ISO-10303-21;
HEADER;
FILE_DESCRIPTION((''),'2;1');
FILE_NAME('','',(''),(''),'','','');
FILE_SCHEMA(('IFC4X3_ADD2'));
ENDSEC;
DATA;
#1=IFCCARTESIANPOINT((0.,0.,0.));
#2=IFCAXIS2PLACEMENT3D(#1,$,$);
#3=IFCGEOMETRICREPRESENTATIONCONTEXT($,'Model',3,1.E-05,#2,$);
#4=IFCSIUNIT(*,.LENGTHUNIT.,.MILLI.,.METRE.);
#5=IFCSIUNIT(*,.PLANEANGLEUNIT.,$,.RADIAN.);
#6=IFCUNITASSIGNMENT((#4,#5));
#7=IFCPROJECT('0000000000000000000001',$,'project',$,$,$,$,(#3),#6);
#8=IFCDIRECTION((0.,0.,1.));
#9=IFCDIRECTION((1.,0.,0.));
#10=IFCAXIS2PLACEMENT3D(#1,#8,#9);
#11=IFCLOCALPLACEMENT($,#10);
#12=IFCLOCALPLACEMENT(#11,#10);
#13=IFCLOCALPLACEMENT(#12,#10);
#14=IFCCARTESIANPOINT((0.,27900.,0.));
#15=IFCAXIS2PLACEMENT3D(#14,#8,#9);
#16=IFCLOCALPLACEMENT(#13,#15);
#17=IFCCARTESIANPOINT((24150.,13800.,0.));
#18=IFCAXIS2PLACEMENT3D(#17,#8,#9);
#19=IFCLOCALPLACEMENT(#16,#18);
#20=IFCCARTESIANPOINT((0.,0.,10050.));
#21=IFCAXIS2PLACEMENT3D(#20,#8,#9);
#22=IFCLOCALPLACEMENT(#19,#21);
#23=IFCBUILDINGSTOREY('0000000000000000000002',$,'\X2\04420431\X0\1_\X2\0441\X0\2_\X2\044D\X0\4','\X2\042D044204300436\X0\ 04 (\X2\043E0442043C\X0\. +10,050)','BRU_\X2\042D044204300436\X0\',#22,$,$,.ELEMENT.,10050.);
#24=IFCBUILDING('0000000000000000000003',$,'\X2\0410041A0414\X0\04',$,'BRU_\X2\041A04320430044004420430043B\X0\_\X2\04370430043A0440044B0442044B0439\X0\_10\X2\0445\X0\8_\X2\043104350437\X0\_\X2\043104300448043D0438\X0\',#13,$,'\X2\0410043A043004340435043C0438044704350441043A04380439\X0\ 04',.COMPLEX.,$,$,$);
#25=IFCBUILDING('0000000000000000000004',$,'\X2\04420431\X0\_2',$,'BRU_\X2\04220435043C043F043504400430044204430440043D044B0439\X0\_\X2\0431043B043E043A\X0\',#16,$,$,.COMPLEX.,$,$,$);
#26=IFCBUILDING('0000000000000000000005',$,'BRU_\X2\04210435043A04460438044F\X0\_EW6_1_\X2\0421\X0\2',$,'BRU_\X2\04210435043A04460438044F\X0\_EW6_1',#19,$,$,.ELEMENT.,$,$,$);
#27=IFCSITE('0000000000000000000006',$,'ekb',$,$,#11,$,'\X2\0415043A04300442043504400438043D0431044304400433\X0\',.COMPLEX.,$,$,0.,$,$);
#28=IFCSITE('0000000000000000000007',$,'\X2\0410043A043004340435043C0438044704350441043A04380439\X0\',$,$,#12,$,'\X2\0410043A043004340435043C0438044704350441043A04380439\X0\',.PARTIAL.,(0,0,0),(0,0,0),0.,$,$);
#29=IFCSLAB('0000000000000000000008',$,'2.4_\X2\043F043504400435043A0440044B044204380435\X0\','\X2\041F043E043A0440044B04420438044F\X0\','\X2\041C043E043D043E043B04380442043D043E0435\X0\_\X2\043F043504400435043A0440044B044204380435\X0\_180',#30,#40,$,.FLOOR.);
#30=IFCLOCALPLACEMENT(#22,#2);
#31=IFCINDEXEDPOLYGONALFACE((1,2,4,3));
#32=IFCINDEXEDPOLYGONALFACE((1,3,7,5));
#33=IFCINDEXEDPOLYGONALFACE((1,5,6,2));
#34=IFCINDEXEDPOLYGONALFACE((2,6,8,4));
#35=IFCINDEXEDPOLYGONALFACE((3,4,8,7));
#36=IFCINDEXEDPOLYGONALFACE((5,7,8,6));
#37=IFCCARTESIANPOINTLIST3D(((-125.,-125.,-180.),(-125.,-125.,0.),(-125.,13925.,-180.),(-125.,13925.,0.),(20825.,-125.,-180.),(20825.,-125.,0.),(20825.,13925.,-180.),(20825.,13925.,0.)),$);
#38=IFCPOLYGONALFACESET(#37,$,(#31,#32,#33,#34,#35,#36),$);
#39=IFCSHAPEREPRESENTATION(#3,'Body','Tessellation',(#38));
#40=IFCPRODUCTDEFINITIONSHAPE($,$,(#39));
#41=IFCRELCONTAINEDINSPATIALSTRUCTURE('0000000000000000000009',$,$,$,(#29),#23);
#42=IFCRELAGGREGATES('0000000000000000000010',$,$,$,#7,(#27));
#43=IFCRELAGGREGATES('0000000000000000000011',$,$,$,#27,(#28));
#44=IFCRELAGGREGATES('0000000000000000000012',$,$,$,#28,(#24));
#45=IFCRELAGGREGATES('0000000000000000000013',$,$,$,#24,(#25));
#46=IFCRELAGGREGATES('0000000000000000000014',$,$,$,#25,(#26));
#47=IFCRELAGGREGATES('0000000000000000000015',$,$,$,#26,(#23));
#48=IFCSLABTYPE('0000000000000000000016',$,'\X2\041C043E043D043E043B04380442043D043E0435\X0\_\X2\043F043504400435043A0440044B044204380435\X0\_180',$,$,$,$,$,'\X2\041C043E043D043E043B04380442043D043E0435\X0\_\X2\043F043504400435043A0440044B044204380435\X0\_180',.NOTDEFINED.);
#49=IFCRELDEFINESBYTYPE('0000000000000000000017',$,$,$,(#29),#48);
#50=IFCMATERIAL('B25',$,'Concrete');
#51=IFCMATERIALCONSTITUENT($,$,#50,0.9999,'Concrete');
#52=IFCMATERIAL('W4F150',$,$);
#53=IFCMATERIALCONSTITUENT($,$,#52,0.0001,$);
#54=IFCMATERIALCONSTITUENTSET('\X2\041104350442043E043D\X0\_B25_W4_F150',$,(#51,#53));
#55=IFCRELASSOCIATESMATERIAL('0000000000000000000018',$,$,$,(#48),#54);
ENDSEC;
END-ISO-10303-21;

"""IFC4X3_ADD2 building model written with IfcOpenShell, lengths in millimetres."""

from ifc_helpers import new_model, si_unit, frame, origin, origin_with_axes, place, context, project, spatial, polyline, outline, extrude, material, constituent, constituent_set, type_object, element, save


model = new_model("IFC4X3_ADD2")

# Units and contexts
model_context = context("Model", 3, precision=1e-05, world=origin())
ifc_project = project(units=[si_unit("LENGTHUNIT", "METRE", prefix="MILLI"), si_unit("PLANEANGLEUNIT", "RADIAN")], contexts=[model_context])

# Sites, buildings, storey
site_1_placement = place(None, origin_with_axes())
site_1 = spatial("IfcSite", under=ifc_project, at=site_1_placement, Name="ekb", LongName="Екатеринбург", CompositionType="COMPLEX", RefElevation=0.0)
site_2_placement = place(site_1_placement, origin_with_axes())
site_2 = spatial("IfcSite", under=site_1, at=site_2_placement, Name="Академический", LongName="Академический", CompositionType="PARTIAL", RefLatitude=(0, 0, 0), RefLongitude=(0, 0, 0), RefElevation=0.0)
building_1_placement = place(site_2_placement, origin_with_axes())
building_1 = spatial("IfcBuilding", under=site_2, at=building_1_placement, Name="АКД04", ObjectType="BRU_Квартал_закрытый_10х8_без_башни", LongName="Академический 04", CompositionType="COMPLEX")
building_2_placement = place(building_1_placement, frame((0.0, 27900.0, 0.0), z_axis=(0.0, 0.0, 1.0), x_axis=(1.0, 0.0, 0.0)))
building_2 = spatial("IfcBuilding", under=building_1, at=building_2_placement, Name="тб_2", ObjectType="BRU_Температурный_блок", CompositionType="COMPLEX")
building_3_placement = place(building_2_placement, frame((24150.0, 13800.0, 0.0), z_axis=(0.0, 0.0, 1.0), x_axis=(1.0, 0.0, 0.0)))
building_3 = spatial("IfcBuilding", under=building_2, at=building_3_placement, Name="BRU_Секция_EW6_1_С2", ObjectType="BRU_Секция_EW6_1", CompositionType="ELEMENT")
storey_placement = place(building_3_placement, frame((0.0, 0.0, 10050.0), z_axis=(0.0, 0.0, 1.0), x_axis=(1.0, 0.0, 0.0)))
storey = spatial("IfcBuildingStorey", under=building_3, at=storey_placement, Name="тб1_с2_э4", Description="Этаж 04 (отм. +10,050)", ObjectType="BRU_Этаж", CompositionType="ELEMENT", Elevation=10050.0)

# Shared definitions
ifc_material_1 = material(Name="B25", Category="Concrete")
ifc_material_2 = material(Name="W4F150")

# Slab
ifc_constituent_1 = constituent(ifc_material_1, Category="Concrete", fraction=0.9999)
ifc_constituent_2 = constituent(ifc_material_2, fraction=0.0001)
ifc_constituent_set_1 = constituent_set(constituents=[ifc_constituent_1, ifc_constituent_2], Name="Бетон_B25_W4_F150")
slab_type = type_object("IfcSlabType", Name="Монолитное_перекрытие_180", ElementType="Монолитное_перекрытие_180", PredefinedType="NOTDEFINED", material=ifc_constituent_set_1)
slab_placement = place(storey_placement, frame((0.0, 0.0, -180.0), z_axis=(0.0, 0.0, 1.0), x_axis=(1.0, 0.0, 0.0)))
element("IfcSlab", 1, at=slab_placement, inside=storey, type_object=slab_type, Name="2.4_перекрытие", Description="Покрытия", ObjectType="Монолитное_перекрытие_180", PredefinedType="FLOOR", context=model_context, shape_type="SweptSolid", body=[
    extrude(outline(polyline([(-125.0, -125.0), (20825.0, -125.0), (20825.0, 13925.0), (-125.0, 13925.0), (-125.0, -125.0)])), origin_with_axes(), (0.0, 0.0, 1.0), 180.0),
])

save(model, "model.ifc")
